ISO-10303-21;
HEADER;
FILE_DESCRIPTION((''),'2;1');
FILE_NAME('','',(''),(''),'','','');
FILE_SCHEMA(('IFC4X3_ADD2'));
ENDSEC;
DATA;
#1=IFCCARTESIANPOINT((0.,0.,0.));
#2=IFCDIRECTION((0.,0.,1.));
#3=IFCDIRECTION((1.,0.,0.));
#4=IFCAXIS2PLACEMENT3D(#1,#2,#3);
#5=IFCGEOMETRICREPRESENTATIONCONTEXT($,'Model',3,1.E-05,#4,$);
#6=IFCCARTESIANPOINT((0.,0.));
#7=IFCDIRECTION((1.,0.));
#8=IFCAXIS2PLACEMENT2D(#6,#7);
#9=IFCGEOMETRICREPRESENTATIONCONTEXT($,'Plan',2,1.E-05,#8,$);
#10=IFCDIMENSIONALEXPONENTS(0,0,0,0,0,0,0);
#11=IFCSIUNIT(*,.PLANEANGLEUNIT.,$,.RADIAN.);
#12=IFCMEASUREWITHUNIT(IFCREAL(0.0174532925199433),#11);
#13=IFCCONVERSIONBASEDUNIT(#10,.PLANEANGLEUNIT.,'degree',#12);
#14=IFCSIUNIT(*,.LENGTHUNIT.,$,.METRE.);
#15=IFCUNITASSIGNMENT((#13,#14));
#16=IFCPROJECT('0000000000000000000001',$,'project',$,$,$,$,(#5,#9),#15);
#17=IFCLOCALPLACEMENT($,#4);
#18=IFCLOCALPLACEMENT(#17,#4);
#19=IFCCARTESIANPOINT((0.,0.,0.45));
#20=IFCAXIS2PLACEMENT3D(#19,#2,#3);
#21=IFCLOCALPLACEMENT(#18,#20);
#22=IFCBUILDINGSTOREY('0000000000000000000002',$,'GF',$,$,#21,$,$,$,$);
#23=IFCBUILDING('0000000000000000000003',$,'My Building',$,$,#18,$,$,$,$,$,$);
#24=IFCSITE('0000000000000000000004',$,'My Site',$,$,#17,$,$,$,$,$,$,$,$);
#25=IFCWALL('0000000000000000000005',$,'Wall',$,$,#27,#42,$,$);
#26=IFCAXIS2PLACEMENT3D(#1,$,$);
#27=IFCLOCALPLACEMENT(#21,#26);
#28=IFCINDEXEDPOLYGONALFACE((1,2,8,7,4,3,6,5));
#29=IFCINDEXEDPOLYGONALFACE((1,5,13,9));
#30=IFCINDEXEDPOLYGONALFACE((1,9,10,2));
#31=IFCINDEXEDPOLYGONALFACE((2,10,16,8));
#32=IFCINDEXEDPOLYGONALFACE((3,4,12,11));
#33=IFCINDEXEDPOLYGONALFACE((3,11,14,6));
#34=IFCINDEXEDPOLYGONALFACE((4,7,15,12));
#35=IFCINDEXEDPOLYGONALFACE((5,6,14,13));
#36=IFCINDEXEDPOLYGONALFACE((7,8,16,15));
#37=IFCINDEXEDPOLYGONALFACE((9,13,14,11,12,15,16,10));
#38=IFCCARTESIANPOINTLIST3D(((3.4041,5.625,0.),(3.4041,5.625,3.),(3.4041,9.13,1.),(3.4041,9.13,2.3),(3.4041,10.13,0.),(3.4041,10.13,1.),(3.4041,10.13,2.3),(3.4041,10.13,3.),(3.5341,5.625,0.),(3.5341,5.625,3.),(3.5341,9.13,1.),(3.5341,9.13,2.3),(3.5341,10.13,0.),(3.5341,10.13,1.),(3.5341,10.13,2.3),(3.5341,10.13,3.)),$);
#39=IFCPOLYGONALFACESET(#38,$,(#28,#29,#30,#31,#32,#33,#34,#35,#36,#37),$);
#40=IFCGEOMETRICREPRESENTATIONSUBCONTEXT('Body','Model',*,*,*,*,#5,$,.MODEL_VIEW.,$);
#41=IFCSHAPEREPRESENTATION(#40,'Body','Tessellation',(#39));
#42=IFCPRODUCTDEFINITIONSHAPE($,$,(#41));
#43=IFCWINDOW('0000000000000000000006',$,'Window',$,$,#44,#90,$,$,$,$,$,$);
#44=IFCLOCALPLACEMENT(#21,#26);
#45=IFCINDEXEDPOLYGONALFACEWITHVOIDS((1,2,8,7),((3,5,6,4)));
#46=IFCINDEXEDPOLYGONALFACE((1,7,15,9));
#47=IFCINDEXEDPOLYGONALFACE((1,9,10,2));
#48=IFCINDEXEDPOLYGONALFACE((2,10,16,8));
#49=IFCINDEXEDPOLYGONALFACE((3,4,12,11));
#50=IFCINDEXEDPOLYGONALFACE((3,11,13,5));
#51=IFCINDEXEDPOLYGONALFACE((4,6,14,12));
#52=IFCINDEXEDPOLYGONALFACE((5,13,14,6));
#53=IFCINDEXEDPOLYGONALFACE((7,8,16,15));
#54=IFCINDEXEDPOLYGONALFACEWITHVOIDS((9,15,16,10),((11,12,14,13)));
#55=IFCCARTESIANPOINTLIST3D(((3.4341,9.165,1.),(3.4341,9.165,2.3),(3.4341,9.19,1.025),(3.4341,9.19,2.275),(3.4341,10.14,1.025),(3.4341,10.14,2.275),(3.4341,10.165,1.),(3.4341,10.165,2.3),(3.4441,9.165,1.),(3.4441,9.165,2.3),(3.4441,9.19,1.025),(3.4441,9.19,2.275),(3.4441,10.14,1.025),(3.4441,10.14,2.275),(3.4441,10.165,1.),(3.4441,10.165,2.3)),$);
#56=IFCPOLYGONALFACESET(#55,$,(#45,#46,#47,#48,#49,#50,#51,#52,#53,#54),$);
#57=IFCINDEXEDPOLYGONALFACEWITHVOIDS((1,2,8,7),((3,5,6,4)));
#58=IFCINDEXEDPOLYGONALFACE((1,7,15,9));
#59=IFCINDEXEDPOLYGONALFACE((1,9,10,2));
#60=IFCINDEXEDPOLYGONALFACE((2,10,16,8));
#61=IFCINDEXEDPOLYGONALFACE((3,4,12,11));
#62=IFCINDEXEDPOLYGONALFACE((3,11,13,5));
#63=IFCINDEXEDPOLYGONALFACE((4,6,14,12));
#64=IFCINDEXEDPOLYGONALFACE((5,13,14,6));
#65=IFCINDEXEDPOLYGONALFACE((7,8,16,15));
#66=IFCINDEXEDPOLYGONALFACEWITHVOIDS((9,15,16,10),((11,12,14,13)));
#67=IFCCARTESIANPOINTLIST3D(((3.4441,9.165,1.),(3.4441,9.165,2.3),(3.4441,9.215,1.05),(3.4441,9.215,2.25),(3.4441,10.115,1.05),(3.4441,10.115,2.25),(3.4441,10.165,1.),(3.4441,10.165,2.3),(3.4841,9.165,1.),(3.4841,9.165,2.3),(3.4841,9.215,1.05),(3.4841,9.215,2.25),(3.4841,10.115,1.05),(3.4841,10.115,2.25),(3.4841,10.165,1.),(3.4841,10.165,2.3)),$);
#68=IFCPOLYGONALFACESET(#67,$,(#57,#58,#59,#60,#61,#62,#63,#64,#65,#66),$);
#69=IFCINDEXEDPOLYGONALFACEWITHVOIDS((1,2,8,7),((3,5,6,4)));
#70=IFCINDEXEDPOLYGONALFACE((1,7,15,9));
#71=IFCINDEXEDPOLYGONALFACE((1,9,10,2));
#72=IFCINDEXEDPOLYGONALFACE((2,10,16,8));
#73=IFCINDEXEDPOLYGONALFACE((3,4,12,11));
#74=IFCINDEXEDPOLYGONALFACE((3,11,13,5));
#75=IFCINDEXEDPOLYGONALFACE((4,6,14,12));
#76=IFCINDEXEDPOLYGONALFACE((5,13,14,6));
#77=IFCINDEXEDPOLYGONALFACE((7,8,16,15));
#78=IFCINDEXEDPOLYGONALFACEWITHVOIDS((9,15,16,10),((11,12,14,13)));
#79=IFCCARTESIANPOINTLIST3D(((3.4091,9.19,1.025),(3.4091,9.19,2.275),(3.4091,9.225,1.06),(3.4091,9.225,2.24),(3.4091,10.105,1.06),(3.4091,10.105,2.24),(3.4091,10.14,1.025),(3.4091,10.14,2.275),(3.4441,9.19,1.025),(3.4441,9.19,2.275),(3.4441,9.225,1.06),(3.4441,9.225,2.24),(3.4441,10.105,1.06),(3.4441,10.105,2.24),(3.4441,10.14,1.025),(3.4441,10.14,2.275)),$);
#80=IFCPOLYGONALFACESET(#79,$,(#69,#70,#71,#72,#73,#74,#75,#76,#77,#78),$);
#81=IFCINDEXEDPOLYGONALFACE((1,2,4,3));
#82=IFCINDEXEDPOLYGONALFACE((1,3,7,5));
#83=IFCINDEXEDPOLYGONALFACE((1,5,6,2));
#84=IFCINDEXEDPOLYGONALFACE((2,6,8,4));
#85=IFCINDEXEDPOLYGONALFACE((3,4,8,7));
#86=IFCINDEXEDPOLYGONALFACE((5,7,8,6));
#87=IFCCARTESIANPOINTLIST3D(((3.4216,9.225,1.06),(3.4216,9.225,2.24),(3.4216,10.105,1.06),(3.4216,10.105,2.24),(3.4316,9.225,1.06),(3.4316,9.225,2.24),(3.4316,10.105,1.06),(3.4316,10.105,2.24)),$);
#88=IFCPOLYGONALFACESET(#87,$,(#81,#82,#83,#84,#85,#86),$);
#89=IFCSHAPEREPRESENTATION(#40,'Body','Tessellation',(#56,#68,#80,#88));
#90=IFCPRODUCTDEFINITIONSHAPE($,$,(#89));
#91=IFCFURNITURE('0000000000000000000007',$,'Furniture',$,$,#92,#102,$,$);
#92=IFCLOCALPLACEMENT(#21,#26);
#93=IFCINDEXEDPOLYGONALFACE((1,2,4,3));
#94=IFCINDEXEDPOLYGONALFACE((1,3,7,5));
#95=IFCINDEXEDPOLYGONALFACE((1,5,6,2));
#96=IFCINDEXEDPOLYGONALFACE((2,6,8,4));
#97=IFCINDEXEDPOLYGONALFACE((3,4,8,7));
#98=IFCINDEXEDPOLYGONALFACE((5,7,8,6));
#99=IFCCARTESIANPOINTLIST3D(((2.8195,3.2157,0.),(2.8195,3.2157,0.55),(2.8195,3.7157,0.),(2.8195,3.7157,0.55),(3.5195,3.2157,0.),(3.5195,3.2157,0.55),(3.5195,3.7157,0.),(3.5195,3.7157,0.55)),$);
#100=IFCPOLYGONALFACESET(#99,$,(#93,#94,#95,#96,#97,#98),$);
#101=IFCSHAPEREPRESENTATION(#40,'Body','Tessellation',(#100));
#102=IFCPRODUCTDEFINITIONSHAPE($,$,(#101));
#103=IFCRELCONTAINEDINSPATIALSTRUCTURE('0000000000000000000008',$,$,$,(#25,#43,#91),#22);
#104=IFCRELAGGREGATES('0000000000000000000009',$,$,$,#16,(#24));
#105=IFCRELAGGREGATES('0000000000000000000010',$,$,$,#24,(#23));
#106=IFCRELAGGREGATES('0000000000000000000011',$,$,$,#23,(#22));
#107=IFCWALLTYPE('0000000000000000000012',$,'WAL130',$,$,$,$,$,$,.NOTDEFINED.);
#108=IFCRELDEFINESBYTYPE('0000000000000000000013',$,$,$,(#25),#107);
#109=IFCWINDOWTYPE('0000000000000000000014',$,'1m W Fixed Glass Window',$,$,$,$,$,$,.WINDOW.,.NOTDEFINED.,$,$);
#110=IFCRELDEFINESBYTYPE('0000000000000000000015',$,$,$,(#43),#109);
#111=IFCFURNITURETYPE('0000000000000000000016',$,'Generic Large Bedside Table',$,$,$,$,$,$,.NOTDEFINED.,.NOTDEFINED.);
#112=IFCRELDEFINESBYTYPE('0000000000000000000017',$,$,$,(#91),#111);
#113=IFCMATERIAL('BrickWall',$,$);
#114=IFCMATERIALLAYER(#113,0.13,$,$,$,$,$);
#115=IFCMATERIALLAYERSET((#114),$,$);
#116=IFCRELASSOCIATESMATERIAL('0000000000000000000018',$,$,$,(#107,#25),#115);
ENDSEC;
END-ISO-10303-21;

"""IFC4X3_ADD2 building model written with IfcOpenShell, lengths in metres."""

from ifc_helpers import new_model, entity, si_unit, converted_unit, frame, origin_with_axes, origin_2d_with_axis, place, context, subcontext, project, spatial, line, indexed_curve, outline, extrude, shape, source, transform, mapped, material, layer, layer_set, layer_usage, type_object, type_shapes, element, fill, save


model = new_model("IFC4X3_ADD2")

# Units and contexts
model_context = context("Model", 3, precision=1e-05, world=origin_with_axes())
plan_context = context("Plan", 2, precision=1e-05, world=origin_2d_with_axis())
body_context_1 = subcontext(model_context, "Body", "Model", "MODEL_VIEW")
body_context_2 = subcontext(plan_context, "Body", "Plan", "PLAN_VIEW")
ifc_project = project(units=[converted_unit("PLANEANGLEUNIT", "degree", entity("IfcReal", 0.0174532925199433), si_unit("PLANEANGLEUNIT", "RADIAN"), dimensions=[0, 0, 0, 0, 0, 0, 0]), si_unit("LENGTHUNIT", "METRE")], contexts=[model_context, plan_context])

# Site, building, storey
site_placement = place(None, origin_with_axes())
site = spatial("IfcSite", under=ifc_project, at=site_placement, Name="My Site")
building_placement = place(site_placement, origin_with_axes())
building = spatial("IfcBuilding", under=site, at=building_placement, Name="My Building")
storey_placement = place(building_placement, frame((0.0, 0.0, 0.45), z_axis=(0.0, 0.0, 1.0), x_axis=(1.0, 0.0, 0.0)))
storey = spatial("IfcBuildingStorey", under=building, at=storey_placement, Name="GF")

# Shared definitions
ifc_material = material(Name="BrickWall")

# Shared definitions
ifc_layer_1 = layer(ifc_material, 0.13)
ifc_layer_set_1 = layer_set([ifc_layer_1])
wall_type_1 = type_object("IfcWallType", Name="WAL130", PredefinedType="NOTDEFINED", material=ifc_layer_set_1)

# Wall, opening, window
ifc_layer_usage_1 = layer_usage(ifc_layer_set_1, "AXIS2", "POSITIVE", 0.0)
wall_1_placement = place(storey_placement, frame((3.5341, 5.625, 0.0), z_axis=(0.0, 0.0, 1.0), x_axis=(0.0, 1.0, 0.0)))
wall_1 = element("IfcWall", 1, at=wall_1_placement, inside=storey, type_object=wall_type_1, material=ifc_layer_usage_1, Name="Wall", context=body_context_1, shape_type="SweptSolid", body=[
    extrude(outline(indexed_curve([(0.0, 0.0), (0.0, 0.13), (4.505, 0.13), (4.505, 0.0), (0.0, 0.0)], self_intersect=False)), origin_with_axes(), (0.0, 0.0, 1.0), 3.0),
])
shared_shape_1 = source(origin_with_axes(), body_context_1, "Body", "SweptSolid", [
    extrude(outline(indexed_curve([(0.0, 0.0), (1.0, 0.0), (1.0, 1.3), (0.0, 1.3)], segments=[line(1, 2, 3, 4, 1)])), frame((0.0, -0.6, 0.0), z_axis=(0.0, -1.0, 0.0), x_axis=(1.0, 0.0, 0.0)), (0.0, 0.0, -1.0), 1.2),
])
opening_1_placement = place(wall_1_placement, frame((3.505, 0.0, 1.0), z_axis=(0.0, 0.0, 1.0), x_axis=(1.0, 0.0, 0.0)))
opening_1 = element("IfcOpeningElement", 2, at=opening_1_placement, cuts=wall_1, PredefinedType="OPENING", context=body_context_1, shape_type="MappedRepresentation", body=[
    mapped(shared_shape_1, transform((0.0, 0.0, 0.0), x_axis=(1.0, 0.0, 0.0), y_axis=(0.0, 1.0, 0.0), z_axis=(0.0, 0.0, 1.0), scale=1.0)),
])
window_type = type_object("IfcWindowType", Name="1m W Fixed Glass Window", PartitioningType="NOTDEFINED", PredefinedType="WINDOW")
shared_shape_2 = source(origin_with_axes(), body_context_1, "Body", "SweptSolid", [
    extrude(outline(indexed_curve([(0.0, 0.0), (1.0, 0.0), (1.0, 1.3), (0.0, 1.3)], segments=[line(1, 2, 3, 4, 1)]), holes=[indexed_curve([(0.025, 0.025), (0.975, 0.025), (0.975, 1.275), (0.025, 1.275)], segments=[line(1, 2, 3, 4, 1)])]), frame((0.0, 0.09, 0.0), z_axis=(0.0, -1.0, 0.0), x_axis=(1.0, 0.0, 0.0)), (0.0, 0.0, -1.0), 0.01),
    extrude(outline(indexed_curve([(0.0, 0.0), (1.0, 0.0), (1.0, 1.3), (0.0, 1.3)], segments=[line(1, 2, 3, 4, 1)]), holes=[indexed_curve([(0.05, 0.05), (0.95, 0.05), (0.95, 1.25), (0.05, 1.25)], segments=[line(1, 2, 3, 4, 1)])]), frame((0.0, 0.05, 0.0), z_axis=(0.0, -1.0, 0.0), x_axis=(1.0, 0.0, 0.0)), (0.0, 0.0, -1.0), 0.04),
    extrude(outline(indexed_curve([(0.0, 0.0), (0.95, 0.0), (0.95, 1.25), (0.0, 1.25)], segments=[line(1, 2, 3, 4, 1)]), holes=[indexed_curve([(0.035, 0.035), (0.915, 0.035), (0.915, 1.215), (0.035, 1.215)], segments=[line(1, 2, 3, 4, 1)])]), frame((0.025, 0.09, 0.025), z_axis=(0.0, -1.0, 0.0), x_axis=(1.0, 0.0, 0.0)), (0.0, 0.0, -1.0), 0.035),
    extrude(outline(indexed_curve([(0.035, 0.035), (0.915, 0.035), (0.915, 1.215), (0.035, 1.215)], segments=[line(1, 2, 3, 4, 1)])), frame((0.025, 0.1025, 0.025), z_axis=(0.0, -1.0, 0.0), x_axis=(1.0, 0.0, 0.0)), (0.0, 0.0, -1.0), 0.01),
])
shared_shape_3 = source(origin_with_axes(), body_context_2, "Body", "Curve2D", [
    entity("IfcIndexedPolyCurve", entity("IfcCartesianPointList2D", [[0.05, 0.05], [0.95, 0.05]])),
    entity("IfcIndexedPolyCurve", entity("IfcCartesianPointList2D", [[0.0, 0.1], [0.025, 0.1], [0.025, 0.09], [0.05, 0.09], [0.05, 0.05], [0.0, 0.05]]), [entity("IfcLineIndex", [1, 2, 3, 4, 5, 6, 1])]),
    entity("IfcIndexedPolyCurve", entity("IfcCartesianPointList2D", [[1.0, 0.1], [0.975, 0.1], [0.975, 0.09], [0.95, 0.09], [0.95, 0.05], [1.0, 0.05]]), [entity("IfcLineIndex", [1, 2, 3, 4, 5, 6, 1])]),
    entity("IfcIndexedPolyCurve", entity("IfcCartesianPointList2D", [[0.025, 0.09], [0.06, 0.09], [0.06, 0.125], [0.025, 0.125]]), [entity("IfcLineIndex", [1, 2, 3, 4, 1])]),
    entity("IfcIndexedPolyCurve", entity("IfcCartesianPointList2D", [[0.975, 0.09], [0.94, 0.09], [0.94, 0.125], [0.975, 0.125]]), [entity("IfcLineIndex", [1, 2, 3, 4, 1])]),
    entity("IfcIndexedPolyCurve", entity("IfcCartesianPointList2D", [[0.06, 0.09], [0.94, 0.09]])),
    entity("IfcIndexedPolyCurve", entity("IfcCartesianPointList2D", [[0.06, 0.125], [0.94, 0.125]])),
    entity("IfcIndexedPolyCurve", entity("IfcCartesianPointList2D", [[0.06, 0.1075], [0.94, 0.1075]])),
])
type_shapes(window_type, [shared_shape_2, shared_shape_3])
window_placement = place(opening_1_placement, frame((0.035, 0.0, 0.0), z_axis=(0.0, 0.0, 1.0), x_axis=(1.0, 0.0, 0.0)))
window = element("IfcWindow", 3, at=window_placement, inside=storey, type_object=window_type, Name="Window", shapes=[
    shape(body_context_1, "Body", "MappedRepresentation", [mapped(shared_shape_2, transform((0.0, 0.0, 0.0), x_axis=(1.0, 0.0, 0.0), y_axis=(0.0, 1.0, 0.0), z_axis=(0.0, 0.0, 1.0), scale=1.0))]),
    shape(body_context_2, "Body", "MappedRepresentation", [mapped(shared_shape_3, transform((0.0, 0.0, 0.0), x_axis=(1.0, 0.0, 0.0), y_axis=(0.0, 1.0, 0.0), z_axis=(0.0, 0.0, 1.0), scale=1.0))]),
])
fill(opening_1, window)

# Furniture
furniture_type = type_object("IfcFurnitureType", Name="Generic Large Bedside Table", AssemblyPlace="NOTDEFINED", PredefinedType="NOTDEFINED")
shared_shape_4 = source(origin_with_axes(), body_context_1, "Body", "SweptSolid", [
    extrude(outline(indexed_curve([(0.0, 0.0), (0.7, 0.0), (0.7, 0.5), (0.0, 0.5)], segments=[line(1, 2, 3, 4, 1)])), frame((-0.35, -0.25, 0.0), z_axis=(0.0, 0.0, 1.0), x_axis=(1.0, 0.0, 0.0)), (0.0, 0.0, 1.0), 0.55),
])
shared_shape_5 = source(origin_with_axes(), body_context_2, "Body", "Curve2D", [
    entity("IfcIndexedPolyCurve", entity("IfcCartesianPointList2D", [[-0.35, -0.25], [0.35, -0.25], [0.35, 0.25], [-0.35, 0.25]]), [entity("IfcLineIndex", [1, 2, 3, 4, 1])]),
])
type_shapes(furniture_type, [shared_shape_4, shared_shape_5])
furniture_placement = place(storey_placement, frame((3.1695, 3.4657, 0.0), z_axis=(0.0, 0.0, 1.0), x_axis=(1.0, 0.0, 0.0)))
element("IfcFurniture", 4, at=furniture_placement, inside=storey, type_object=furniture_type, Name="Furniture", shapes=[
    shape(body_context_1, "Body", "MappedRepresentation", [mapped(shared_shape_4, transform((0.0, 0.0, 0.0), x_axis=(1.0, 0.0, 0.0), y_axis=(0.0, 1.0, 0.0), z_axis=(0.0, 0.0, 1.0), scale=1.0))]),
    shape(body_context_2, "Body", "MappedRepresentation", [mapped(shared_shape_5, transform((0.0, 0.0, 0.0), x_axis=(1.0, 0.0, 0.0), y_axis=(0.0, 1.0, 0.0), z_axis=(0.0, 0.0, 1.0), scale=1.0))]),
])

save(model, "model.ifc")
